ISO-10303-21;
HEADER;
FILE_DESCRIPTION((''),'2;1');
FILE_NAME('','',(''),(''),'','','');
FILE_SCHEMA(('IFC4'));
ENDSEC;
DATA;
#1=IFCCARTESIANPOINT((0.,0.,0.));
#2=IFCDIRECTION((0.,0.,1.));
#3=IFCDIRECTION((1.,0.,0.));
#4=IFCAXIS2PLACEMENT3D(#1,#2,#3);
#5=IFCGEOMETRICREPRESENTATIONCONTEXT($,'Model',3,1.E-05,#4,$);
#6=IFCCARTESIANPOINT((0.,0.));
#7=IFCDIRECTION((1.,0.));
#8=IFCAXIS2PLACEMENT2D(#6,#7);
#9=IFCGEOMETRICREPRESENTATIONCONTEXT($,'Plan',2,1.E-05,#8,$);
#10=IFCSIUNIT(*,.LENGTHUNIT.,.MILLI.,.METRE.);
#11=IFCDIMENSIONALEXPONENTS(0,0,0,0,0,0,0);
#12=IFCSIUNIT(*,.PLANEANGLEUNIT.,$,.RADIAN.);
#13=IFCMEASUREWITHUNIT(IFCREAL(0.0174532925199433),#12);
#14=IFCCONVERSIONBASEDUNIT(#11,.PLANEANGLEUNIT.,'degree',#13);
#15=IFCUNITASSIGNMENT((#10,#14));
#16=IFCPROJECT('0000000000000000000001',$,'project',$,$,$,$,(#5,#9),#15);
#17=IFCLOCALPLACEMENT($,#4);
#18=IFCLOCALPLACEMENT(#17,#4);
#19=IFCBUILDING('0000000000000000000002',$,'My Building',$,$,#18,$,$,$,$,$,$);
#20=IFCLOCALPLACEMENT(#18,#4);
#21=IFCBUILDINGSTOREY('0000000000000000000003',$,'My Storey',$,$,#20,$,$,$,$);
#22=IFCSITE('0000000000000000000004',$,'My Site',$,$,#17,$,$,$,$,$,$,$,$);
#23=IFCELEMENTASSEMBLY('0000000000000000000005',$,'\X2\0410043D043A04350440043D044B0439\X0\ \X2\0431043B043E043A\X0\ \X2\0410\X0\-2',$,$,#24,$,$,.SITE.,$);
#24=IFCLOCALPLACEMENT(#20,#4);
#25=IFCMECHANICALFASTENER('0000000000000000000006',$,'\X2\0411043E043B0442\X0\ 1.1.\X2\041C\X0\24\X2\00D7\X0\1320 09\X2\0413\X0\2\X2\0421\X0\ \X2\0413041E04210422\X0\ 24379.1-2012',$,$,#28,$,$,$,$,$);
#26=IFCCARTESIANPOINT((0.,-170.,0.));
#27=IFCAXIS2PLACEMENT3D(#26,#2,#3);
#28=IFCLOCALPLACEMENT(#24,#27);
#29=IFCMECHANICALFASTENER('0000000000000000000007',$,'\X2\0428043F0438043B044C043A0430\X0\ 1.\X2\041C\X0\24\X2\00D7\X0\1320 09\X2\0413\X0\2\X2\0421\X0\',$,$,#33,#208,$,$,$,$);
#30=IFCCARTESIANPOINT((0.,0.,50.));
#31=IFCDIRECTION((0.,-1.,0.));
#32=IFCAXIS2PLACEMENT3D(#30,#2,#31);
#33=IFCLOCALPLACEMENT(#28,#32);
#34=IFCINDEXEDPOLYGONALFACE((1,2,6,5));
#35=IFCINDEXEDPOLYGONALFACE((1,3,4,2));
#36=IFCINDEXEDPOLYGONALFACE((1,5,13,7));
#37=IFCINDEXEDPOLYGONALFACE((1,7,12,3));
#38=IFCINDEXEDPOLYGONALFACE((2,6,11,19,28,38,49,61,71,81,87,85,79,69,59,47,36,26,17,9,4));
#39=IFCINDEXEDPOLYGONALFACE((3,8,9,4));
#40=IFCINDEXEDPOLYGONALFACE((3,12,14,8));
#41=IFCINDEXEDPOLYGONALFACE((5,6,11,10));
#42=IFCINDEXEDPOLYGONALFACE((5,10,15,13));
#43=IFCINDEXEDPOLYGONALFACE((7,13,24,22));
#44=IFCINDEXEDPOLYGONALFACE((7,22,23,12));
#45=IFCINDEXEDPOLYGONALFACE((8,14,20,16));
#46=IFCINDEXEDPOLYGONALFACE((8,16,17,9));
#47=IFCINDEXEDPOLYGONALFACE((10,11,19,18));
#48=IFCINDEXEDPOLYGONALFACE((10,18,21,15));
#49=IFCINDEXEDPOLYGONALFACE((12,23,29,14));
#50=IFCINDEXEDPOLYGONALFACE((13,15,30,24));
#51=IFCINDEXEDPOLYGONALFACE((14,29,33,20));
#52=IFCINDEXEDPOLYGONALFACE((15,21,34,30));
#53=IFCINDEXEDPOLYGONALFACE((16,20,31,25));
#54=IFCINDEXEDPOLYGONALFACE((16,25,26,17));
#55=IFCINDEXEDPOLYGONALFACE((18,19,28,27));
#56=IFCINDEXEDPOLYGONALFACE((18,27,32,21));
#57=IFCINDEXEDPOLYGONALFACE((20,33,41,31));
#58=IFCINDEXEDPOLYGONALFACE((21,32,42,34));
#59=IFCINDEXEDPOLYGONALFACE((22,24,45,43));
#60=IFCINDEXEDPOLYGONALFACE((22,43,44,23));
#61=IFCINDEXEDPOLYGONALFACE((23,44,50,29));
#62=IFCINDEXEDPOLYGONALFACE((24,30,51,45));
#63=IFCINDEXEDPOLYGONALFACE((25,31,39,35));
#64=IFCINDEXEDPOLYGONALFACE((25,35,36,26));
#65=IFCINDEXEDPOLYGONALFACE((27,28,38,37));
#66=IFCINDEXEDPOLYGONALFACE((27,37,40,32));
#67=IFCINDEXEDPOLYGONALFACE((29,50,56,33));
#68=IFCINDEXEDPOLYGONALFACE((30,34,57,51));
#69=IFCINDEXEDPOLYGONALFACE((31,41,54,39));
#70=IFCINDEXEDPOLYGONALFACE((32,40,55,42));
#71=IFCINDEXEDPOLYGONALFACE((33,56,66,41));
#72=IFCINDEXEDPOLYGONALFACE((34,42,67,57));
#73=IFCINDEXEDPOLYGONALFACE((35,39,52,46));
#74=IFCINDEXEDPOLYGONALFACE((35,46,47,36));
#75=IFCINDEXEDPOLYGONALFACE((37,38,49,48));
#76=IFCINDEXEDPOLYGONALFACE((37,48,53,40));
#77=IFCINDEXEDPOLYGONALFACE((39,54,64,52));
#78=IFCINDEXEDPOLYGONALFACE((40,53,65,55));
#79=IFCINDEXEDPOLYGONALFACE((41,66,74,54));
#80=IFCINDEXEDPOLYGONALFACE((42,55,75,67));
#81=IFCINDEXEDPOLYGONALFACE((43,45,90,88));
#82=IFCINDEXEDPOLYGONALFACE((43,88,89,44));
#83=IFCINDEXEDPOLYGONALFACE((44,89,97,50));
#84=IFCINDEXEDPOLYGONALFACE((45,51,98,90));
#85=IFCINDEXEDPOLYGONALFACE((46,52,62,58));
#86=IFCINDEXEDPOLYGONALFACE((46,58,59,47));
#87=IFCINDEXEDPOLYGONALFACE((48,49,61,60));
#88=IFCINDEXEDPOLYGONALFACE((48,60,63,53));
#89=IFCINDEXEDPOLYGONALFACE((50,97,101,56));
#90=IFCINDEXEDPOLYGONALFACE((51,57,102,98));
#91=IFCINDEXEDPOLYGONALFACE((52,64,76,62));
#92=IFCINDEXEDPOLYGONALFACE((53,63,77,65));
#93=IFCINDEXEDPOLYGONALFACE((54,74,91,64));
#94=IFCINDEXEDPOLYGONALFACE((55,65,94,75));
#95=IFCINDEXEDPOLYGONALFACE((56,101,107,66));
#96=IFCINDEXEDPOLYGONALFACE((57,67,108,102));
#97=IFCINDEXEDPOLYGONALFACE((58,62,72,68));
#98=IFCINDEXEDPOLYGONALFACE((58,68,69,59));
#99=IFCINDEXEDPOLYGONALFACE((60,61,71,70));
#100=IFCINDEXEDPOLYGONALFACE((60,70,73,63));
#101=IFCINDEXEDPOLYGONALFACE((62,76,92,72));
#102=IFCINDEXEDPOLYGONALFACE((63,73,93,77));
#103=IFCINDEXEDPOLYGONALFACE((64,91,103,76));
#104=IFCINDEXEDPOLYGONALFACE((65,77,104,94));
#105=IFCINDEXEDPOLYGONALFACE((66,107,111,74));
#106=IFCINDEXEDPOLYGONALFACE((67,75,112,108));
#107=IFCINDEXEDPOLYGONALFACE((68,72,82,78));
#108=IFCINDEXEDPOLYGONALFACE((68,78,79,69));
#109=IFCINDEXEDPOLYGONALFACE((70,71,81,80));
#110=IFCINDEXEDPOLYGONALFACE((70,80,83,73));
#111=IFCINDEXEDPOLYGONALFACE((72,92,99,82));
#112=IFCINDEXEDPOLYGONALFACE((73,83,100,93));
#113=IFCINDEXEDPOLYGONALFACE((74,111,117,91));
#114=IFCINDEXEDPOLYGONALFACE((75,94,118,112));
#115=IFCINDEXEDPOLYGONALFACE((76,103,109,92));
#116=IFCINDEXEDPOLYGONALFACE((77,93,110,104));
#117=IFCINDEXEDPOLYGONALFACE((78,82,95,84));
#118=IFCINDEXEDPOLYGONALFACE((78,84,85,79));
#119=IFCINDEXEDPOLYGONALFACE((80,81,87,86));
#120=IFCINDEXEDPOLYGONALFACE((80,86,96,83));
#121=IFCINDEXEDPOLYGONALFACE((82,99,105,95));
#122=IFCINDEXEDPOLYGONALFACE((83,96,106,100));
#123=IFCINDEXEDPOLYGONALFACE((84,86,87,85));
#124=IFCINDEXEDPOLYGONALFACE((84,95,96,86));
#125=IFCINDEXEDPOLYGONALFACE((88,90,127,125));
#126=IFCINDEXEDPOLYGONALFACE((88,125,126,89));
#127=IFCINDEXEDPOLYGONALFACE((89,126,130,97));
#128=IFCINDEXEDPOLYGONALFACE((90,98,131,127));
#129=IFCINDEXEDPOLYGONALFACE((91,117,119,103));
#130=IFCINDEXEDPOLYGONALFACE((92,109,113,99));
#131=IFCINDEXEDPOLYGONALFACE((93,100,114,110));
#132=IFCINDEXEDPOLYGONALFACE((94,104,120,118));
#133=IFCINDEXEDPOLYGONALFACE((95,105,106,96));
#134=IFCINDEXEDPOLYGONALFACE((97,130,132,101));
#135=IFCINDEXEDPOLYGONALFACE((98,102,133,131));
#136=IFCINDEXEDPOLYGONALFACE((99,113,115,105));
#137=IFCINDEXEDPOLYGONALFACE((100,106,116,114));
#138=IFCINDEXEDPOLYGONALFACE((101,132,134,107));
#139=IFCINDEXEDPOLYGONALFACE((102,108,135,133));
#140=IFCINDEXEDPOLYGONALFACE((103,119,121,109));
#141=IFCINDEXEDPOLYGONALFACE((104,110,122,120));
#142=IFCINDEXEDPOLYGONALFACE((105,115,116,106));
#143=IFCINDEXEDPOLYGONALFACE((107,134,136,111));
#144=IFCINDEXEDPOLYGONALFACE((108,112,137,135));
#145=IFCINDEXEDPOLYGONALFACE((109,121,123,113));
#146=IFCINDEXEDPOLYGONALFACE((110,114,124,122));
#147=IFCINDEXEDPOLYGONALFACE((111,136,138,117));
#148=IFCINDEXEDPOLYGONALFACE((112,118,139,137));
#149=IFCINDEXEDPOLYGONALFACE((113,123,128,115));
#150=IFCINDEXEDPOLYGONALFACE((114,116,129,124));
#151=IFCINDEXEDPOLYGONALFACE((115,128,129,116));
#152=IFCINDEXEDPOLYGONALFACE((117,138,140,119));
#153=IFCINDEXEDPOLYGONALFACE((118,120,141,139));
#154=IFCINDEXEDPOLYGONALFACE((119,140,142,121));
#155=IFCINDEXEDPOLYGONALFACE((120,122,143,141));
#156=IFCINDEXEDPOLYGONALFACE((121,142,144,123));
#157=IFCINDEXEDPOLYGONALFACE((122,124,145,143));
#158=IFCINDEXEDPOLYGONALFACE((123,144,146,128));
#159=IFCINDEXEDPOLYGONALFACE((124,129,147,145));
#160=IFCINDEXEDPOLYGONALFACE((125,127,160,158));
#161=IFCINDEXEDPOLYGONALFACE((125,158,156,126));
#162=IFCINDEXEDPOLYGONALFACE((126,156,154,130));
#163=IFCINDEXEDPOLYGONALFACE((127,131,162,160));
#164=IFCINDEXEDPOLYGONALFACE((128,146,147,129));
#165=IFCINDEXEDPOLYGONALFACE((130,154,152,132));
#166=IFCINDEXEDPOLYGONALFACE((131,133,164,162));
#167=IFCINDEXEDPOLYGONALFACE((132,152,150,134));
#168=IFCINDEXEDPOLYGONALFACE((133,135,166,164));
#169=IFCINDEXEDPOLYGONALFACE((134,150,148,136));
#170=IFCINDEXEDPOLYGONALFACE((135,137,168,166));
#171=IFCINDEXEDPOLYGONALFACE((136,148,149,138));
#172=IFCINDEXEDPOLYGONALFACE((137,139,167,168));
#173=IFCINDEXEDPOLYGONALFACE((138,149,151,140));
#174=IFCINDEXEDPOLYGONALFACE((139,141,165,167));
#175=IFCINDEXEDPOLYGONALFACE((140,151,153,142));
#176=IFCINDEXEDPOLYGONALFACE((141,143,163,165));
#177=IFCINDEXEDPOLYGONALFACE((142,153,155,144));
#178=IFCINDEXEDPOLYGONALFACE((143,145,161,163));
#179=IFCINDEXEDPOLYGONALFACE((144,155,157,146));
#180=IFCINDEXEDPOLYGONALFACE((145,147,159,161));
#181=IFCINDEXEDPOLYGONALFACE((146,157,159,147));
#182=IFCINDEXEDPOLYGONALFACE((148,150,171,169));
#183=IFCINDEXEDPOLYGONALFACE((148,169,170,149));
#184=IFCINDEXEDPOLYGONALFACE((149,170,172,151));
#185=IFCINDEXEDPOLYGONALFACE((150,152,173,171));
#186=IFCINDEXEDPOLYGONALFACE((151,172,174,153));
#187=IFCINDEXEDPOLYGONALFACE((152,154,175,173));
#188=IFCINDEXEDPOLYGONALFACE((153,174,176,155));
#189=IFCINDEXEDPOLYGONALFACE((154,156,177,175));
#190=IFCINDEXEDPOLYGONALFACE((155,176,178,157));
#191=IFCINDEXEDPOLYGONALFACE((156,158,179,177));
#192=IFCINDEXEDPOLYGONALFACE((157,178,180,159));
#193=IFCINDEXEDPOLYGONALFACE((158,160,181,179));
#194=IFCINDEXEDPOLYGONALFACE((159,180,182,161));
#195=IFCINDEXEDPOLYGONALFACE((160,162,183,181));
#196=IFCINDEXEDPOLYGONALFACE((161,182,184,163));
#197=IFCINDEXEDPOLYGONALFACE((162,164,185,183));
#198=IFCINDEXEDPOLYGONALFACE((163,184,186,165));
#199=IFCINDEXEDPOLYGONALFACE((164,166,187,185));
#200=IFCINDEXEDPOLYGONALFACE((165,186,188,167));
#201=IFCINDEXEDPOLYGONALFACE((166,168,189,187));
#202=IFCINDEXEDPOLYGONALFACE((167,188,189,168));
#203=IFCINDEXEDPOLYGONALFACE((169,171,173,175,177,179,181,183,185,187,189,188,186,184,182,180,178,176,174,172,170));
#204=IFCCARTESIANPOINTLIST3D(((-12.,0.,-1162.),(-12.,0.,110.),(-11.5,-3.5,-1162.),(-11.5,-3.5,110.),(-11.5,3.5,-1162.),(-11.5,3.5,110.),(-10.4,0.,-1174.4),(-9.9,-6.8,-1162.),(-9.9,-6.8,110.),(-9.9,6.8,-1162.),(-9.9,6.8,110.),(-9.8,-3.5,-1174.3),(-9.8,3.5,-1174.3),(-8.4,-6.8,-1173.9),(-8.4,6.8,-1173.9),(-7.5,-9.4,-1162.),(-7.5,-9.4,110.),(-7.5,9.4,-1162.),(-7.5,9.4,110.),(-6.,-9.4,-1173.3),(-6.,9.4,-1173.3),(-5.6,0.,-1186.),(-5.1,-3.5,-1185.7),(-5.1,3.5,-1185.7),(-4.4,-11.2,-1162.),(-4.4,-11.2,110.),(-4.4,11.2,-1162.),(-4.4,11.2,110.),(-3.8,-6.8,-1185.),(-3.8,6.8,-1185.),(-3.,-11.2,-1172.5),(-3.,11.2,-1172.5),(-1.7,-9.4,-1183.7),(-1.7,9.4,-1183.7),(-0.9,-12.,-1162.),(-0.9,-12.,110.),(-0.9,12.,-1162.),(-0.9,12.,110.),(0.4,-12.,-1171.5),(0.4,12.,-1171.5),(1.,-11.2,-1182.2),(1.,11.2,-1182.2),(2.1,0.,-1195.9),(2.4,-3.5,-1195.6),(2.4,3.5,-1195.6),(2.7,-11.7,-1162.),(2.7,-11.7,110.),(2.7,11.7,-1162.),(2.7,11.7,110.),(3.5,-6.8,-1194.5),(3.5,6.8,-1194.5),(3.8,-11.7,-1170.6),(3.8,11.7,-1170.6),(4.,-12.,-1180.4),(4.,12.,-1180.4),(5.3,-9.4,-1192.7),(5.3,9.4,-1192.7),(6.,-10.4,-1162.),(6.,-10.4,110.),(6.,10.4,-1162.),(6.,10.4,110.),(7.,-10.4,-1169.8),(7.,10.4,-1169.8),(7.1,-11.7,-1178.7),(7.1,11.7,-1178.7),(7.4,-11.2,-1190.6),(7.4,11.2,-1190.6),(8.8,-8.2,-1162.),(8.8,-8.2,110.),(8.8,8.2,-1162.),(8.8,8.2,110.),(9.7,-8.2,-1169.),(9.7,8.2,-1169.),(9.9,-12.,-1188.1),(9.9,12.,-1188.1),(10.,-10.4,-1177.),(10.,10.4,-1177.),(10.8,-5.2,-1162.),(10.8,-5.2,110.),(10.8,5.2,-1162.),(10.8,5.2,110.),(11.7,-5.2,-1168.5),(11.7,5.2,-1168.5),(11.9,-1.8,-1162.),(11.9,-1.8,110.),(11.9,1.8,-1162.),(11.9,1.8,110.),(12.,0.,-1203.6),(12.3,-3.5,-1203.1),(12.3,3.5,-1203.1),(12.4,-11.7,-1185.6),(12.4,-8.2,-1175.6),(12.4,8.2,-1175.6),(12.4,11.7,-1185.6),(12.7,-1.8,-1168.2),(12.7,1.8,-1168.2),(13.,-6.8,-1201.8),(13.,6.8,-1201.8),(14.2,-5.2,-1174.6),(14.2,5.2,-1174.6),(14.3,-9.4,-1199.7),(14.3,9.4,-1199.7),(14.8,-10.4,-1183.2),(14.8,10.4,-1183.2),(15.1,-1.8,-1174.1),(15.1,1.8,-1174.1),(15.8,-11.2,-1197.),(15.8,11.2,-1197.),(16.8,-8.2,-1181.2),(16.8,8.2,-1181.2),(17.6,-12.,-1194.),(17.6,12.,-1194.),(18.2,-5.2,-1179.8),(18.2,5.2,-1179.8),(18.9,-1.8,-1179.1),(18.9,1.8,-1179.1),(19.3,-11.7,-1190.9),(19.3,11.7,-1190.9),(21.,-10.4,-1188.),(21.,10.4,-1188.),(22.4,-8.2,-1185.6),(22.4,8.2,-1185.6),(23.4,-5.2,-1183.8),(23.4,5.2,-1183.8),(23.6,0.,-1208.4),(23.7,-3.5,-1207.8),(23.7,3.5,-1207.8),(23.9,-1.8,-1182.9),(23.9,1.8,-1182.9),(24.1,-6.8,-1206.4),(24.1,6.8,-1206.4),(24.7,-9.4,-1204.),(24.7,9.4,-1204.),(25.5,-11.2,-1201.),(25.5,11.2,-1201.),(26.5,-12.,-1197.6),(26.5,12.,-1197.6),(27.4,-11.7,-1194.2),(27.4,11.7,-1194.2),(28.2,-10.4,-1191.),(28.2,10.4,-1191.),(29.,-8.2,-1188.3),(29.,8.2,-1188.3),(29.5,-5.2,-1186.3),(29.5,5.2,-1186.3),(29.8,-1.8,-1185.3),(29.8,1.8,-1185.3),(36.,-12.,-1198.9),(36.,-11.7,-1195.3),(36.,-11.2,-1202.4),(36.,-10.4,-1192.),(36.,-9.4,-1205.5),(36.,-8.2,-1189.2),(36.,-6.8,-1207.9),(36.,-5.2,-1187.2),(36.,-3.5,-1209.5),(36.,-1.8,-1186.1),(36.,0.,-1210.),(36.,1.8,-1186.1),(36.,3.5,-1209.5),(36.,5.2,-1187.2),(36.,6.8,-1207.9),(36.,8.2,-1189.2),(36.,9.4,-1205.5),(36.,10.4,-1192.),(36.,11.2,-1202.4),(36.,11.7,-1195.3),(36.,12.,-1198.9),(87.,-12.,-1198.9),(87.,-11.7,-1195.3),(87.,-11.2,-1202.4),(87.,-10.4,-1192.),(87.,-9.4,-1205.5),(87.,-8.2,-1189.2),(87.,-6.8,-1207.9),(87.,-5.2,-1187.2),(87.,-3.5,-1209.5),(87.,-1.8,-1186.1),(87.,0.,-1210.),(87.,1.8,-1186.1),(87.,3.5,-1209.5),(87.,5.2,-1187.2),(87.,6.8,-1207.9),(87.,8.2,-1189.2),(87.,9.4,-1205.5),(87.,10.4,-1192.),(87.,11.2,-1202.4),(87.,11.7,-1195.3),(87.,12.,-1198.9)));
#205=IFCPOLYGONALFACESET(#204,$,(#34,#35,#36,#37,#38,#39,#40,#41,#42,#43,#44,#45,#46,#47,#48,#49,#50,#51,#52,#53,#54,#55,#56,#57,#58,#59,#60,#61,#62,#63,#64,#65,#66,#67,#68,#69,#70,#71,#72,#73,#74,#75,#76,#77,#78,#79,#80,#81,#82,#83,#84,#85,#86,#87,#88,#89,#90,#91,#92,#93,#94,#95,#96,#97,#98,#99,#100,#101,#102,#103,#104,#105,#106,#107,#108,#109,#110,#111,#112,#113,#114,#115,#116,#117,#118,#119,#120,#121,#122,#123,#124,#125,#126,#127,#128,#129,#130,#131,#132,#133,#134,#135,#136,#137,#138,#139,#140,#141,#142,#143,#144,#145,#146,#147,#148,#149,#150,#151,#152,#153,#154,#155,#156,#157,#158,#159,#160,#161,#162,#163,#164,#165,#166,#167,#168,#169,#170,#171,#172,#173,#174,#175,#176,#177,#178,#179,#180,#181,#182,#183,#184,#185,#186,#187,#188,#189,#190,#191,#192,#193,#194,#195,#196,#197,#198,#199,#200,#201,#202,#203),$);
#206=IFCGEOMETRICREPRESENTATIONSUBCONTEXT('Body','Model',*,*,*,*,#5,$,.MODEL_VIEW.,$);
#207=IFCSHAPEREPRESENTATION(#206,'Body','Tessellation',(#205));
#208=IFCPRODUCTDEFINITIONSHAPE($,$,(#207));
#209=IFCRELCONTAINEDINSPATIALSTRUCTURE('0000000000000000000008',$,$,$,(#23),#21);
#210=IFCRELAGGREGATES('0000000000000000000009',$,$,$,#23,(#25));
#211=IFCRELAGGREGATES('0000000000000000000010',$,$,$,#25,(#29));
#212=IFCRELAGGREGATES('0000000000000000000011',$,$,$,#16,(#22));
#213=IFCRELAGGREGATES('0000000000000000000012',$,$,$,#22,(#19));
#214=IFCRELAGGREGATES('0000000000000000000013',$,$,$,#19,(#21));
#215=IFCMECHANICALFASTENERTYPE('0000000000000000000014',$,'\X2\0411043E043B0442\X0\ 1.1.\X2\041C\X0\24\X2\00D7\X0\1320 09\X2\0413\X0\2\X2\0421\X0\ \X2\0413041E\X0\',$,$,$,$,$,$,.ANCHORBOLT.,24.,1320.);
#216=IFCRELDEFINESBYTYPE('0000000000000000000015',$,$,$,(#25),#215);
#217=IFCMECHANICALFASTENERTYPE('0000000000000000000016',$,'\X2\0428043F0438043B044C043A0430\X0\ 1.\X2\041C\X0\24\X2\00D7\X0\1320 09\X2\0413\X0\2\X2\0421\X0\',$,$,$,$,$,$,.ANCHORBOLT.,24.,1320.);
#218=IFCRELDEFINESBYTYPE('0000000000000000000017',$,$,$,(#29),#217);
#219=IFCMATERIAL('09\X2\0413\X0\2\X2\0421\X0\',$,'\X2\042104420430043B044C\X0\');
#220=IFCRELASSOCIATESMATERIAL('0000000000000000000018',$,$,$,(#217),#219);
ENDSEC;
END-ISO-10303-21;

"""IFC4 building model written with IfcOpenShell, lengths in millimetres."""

from ifc_helpers import new_model, entity, si_unit, converted_unit, frame, origin_with_axes, origin_2d_with_axis, place, context, subcontext, project, spatial, source, transform, mapped, material, type_object, type_shapes, element, aggregate, save


model = new_model("IFC4")

# Units and contexts
model_context = context("Model", 3, precision=1e-05, world=origin_with_axes())
plan_context = context("Plan", 2, precision=1e-05, world=origin_2d_with_axis())
body_context = subcontext(model_context, "Body", "Model", "MODEL_VIEW")
ifc_project = project(units=[si_unit("LENGTHUNIT", "METRE", prefix="MILLI"), converted_unit("PLANEANGLEUNIT", "degree", entity("IfcReal", 0.0174532925199433), si_unit("PLANEANGLEUNIT", "RADIAN"), dimensions=[0, 0, 0, 0, 0, 0, 0])], contexts=[model_context, plan_context])

# Site, building, storey
site_placement = place(None, origin_with_axes())
site = spatial("IfcSite", under=ifc_project, at=site_placement, Name="My Site")
building_placement = place(site_placement, origin_with_axes())
building = spatial("IfcBuilding", under=site, at=building_placement, Name="My Building")
storey_placement = place(building_placement, origin_with_axes())
storey = spatial("IfcBuildingStorey", under=building, at=storey_placement, Name="My Storey")

# Shared definitions
placement = place(storey_placement, origin_with_axes())

# Element assembly, mechanical fasteners
assembly = element("IfcElementAssembly", 1, at=placement, inside=storey, Name="Анкерный блок А-2", AssemblyPlace="SITE")
mechanical_fastener_type_1 = type_object("IfcMechanicalFastenerType", Name="Болт 1.1.М24×1320 09Г2С ГО", NominalDiameter=24.0, NominalLength=1320.0, PredefinedType="ANCHORBOLT")
mechanical_fastener_1_placement = place(placement, frame((0.0, -170.0, 0.0), z_axis=(0.0, 0.0, 1.0), x_axis=(1.0, 0.0, 0.0)))
mechanical_fastener_1 = element("IfcMechanicalFastener", 2, at=mechanical_fastener_1_placement, type_object=mechanical_fastener_type_1, Name="Болт 1.1.М24×1320 09Г2С ГОСТ 24379.1-2012")
aggregate(assembly, [mechanical_fastener_1])
ifc_material_1 = material(Name="09Г2С", Category="Сталь")
mechanical_fastener_type_2 = type_object("IfcMechanicalFastenerType", Name="Шпилька 1.М24×1320 09Г2С", NominalDiameter=24.0, NominalLength=1320.0, PredefinedType="ANCHORBOLT", material=ifc_material_1)
shared_shape_1 = source(frame((0.0, 0.0, 110.0), z_axis=(0.0, 0.0, 1.0), x_axis=(1.0, 0.0, 0.0)), body_context, "Body", "AdvancedSweptSolid", [
    entity("IfcSweptDiskSolid", entity("IfcIndexedPolyCurve", entity("IfcCartesianPointList3D", [[0.0, 0.0, 0.0], [0.0, 0.0, -1272.0], [10.5, 0.0, -1297.5], [36.0, 0.0, -1308.0], [87.0, 0.0, -1308.0]]), [entity("IfcLineIndex", [1, 2]), entity("IfcArcIndex", [2, 3, 4]), entity("IfcLineIndex", [4, 5])]), 12.0),
])
type_shapes(mechanical_fastener_type_2, [shared_shape_1])
mechanical_fastener_2_placement = place(mechanical_fastener_1_placement, frame((0.0, 0.0, 50.0), z_axis=(0.0, 0.0, 1.0), x_axis=(0.0, -1.0, 0.0)))
mechanical_fastener_2 = element("IfcMechanicalFastener", 3, at=mechanical_fastener_2_placement, type_object=mechanical_fastener_type_2, Name="Шпилька 1.М24×1320 09Г2С", context=body_context, shape_type="MappedRepresentation", body=[
    mapped(shared_shape_1, transform((0.0, 0.0, 0.0), x_axis=(1.0, 0.0, 0.0), y_axis=(0.0, 1.0, 0.0), z_axis=(0.0, 0.0, 1.0), scale=1.0)),
])
aggregate(mechanical_fastener_1, [mechanical_fastener_2])

save(model, "model.ifc")
